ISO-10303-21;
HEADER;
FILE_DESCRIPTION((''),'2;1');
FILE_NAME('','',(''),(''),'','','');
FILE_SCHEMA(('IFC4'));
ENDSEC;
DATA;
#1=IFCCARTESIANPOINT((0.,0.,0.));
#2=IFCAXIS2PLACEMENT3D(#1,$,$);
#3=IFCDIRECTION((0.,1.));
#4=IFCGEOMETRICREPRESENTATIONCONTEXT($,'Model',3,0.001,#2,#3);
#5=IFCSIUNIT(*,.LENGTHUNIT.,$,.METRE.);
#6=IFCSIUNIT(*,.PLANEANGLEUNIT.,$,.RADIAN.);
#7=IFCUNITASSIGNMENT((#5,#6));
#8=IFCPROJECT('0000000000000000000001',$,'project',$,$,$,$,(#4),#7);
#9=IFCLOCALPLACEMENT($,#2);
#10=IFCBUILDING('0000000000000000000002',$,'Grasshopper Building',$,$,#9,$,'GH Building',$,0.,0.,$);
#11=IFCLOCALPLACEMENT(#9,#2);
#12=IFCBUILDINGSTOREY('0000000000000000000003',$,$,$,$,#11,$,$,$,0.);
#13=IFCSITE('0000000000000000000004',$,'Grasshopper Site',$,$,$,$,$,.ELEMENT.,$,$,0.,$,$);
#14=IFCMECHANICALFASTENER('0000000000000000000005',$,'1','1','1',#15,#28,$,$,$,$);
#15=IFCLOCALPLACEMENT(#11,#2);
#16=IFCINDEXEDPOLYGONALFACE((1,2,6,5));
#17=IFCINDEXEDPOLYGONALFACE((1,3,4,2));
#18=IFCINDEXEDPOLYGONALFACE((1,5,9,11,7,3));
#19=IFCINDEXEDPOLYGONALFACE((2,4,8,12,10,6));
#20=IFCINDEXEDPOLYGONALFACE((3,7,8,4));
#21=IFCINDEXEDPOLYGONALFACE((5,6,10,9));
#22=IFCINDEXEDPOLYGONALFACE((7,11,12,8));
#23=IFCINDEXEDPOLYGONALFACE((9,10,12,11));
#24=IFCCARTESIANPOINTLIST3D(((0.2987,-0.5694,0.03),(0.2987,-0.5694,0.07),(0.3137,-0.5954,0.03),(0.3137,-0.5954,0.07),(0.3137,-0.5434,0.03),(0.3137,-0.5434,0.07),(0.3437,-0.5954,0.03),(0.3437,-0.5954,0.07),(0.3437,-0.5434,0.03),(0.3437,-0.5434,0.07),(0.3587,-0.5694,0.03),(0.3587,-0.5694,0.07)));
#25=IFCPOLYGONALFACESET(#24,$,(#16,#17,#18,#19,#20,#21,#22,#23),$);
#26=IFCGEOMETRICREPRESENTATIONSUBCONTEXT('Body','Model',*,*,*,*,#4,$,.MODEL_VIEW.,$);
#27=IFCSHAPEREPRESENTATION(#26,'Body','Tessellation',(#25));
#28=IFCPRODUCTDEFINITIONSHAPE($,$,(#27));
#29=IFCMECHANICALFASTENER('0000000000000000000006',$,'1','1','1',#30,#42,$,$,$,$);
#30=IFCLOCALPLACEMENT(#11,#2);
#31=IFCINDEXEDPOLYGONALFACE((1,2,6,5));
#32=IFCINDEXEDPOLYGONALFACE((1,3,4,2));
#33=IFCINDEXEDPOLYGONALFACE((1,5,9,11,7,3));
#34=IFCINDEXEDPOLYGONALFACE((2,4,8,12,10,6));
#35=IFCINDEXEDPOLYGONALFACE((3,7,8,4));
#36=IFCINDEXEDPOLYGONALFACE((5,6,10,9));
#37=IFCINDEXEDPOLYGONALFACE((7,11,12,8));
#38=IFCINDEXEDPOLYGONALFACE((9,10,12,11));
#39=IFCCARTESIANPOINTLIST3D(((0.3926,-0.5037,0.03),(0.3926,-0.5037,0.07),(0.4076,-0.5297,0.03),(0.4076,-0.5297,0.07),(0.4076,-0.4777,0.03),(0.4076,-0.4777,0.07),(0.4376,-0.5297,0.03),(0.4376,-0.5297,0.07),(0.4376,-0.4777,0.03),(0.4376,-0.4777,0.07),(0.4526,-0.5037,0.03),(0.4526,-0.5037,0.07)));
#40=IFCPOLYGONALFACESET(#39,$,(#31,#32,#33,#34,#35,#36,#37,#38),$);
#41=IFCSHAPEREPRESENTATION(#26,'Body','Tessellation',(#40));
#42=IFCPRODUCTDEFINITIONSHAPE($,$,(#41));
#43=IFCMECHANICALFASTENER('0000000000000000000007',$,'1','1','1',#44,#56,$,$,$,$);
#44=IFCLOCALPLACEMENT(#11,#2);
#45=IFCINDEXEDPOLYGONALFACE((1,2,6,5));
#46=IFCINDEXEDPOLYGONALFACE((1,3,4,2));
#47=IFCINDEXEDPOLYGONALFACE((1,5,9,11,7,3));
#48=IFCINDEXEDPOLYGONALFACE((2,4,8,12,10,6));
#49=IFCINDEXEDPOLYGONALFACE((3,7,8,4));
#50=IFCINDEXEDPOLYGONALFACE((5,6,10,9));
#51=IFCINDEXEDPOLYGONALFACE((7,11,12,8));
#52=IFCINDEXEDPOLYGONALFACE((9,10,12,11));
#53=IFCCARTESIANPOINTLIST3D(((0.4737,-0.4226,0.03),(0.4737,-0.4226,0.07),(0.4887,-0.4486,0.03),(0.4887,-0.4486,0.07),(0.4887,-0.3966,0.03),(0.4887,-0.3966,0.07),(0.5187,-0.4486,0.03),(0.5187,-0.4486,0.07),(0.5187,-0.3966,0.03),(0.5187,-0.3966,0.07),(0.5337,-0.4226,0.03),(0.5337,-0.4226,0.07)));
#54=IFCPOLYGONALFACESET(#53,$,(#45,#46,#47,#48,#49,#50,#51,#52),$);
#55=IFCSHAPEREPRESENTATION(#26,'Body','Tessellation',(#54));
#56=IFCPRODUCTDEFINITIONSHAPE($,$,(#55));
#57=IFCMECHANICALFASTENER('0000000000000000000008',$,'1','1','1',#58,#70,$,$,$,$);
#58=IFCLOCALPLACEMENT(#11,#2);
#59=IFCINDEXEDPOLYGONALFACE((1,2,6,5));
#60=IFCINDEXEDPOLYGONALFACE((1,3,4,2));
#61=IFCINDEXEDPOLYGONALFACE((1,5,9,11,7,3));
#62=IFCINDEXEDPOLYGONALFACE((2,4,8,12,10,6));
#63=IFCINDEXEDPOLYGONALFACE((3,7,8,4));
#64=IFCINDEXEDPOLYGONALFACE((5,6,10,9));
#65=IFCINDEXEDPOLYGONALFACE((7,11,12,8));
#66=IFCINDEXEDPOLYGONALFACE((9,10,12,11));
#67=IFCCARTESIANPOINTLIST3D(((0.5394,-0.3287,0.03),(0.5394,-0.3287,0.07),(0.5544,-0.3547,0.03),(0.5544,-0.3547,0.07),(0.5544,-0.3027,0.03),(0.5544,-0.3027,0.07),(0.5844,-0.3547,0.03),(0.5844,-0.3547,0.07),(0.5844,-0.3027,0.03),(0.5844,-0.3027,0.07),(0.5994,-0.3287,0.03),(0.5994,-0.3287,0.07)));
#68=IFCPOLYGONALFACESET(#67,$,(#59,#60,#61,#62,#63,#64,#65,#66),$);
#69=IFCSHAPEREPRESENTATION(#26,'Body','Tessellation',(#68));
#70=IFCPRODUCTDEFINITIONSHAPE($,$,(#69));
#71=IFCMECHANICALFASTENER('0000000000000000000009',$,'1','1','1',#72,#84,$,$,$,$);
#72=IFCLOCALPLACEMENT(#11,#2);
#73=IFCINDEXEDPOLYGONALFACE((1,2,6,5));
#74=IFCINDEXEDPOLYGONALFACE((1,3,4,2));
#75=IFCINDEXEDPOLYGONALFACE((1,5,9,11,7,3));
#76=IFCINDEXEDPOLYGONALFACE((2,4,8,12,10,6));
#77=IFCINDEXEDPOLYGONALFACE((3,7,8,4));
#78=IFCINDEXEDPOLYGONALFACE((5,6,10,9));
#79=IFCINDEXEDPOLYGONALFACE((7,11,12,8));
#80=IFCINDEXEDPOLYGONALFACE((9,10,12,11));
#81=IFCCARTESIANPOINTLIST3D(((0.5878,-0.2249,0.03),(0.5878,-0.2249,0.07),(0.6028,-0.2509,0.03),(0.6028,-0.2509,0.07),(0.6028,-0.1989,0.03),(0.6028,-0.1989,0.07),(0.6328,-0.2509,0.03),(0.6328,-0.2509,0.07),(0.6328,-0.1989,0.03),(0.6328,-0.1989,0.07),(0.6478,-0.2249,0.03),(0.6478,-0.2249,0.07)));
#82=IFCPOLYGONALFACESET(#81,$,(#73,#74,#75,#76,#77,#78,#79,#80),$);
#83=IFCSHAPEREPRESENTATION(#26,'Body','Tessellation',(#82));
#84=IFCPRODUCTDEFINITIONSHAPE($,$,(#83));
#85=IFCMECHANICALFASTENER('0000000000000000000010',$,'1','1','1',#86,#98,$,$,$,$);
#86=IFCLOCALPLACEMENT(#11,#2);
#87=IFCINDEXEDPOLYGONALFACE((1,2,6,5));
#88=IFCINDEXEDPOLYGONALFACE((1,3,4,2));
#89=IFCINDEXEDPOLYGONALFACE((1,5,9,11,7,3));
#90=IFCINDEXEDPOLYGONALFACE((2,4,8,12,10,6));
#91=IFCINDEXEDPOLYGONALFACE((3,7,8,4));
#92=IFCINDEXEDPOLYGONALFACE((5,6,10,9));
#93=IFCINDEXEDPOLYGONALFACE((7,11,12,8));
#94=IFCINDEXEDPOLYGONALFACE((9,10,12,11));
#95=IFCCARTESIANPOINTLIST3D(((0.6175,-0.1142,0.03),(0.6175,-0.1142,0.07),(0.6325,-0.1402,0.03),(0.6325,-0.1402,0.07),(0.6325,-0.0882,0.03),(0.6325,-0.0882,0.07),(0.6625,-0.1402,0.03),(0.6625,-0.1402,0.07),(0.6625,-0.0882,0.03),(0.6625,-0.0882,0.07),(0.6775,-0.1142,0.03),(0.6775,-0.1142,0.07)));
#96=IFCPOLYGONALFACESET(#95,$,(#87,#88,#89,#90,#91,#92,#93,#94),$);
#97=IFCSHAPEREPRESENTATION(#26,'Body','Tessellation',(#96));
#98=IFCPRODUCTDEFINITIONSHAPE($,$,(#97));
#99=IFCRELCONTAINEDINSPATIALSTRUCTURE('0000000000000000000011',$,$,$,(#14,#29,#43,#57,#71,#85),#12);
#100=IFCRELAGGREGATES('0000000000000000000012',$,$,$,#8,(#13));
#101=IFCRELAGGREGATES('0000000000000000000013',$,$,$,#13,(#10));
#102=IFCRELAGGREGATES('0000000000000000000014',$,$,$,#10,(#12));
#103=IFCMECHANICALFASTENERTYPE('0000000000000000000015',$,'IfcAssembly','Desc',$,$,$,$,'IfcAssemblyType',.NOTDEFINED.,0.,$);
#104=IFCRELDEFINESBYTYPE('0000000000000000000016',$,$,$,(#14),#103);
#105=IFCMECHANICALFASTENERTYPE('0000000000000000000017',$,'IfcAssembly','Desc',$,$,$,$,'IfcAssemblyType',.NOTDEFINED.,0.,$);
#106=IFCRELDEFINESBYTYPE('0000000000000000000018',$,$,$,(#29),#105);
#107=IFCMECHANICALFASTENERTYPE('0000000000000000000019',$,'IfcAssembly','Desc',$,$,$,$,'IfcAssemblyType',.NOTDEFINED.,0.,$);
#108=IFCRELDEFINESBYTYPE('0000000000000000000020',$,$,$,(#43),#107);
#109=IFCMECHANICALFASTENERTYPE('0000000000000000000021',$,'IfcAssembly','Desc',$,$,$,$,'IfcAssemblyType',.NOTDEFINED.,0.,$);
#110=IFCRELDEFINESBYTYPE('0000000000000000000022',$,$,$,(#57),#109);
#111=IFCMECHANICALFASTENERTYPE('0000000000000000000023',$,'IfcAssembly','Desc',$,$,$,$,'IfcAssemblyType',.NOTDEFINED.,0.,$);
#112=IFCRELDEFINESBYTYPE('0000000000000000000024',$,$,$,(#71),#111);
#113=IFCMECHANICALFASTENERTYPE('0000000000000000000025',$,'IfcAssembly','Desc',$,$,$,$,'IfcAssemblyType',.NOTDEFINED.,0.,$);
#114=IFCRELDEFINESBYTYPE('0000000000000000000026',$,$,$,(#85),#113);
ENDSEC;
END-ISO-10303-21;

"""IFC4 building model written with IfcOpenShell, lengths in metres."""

from ifc_helpers import new_model, si_unit, direction, frame, origin, place, context, subcontext, project, spatial, indexed_curve, outline, extrude, source, transform, mapped, type_object, type_shapes, element, save


model = new_model("IFC4")

# Units and contexts
model_context = context("Model", 3, precision=0.001, world=origin(), true_north=direction((0.0, 1.0)))
body_context = subcontext(model_context, "Body", "Model", "MODEL_VIEW")
ifc_project = project(units=[si_unit("LENGTHUNIT", "METRE"), si_unit("PLANEANGLEUNIT", "RADIAN")], contexts=[model_context])

# Site, building, storey
site = spatial("IfcSite", under=ifc_project, Name="Grasshopper Site", CompositionType="ELEMENT", RefElevation=0.0)
building_placement = place(None, origin())
building = spatial("IfcBuilding", under=site, at=building_placement, Name="Grasshopper Building", LongName="GH Building", ElevationOfRefHeight=0.0, ElevationOfTerrain=0.0)
storey_placement = place(building_placement, origin())
storey = spatial("IfcBuildingStorey", under=building, at=storey_placement, Elevation=0.0)

# Mechanical fasteners
mechanical_fastener_type_1 = type_object("IfcMechanicalFastenerType", Name="IfcAssembly", Description="Desc", ElementType="IfcAssemblyType", NominalDiameter=0.0)
shared_shape_1 = source(origin(), body_context, "Body", "SweptSolid", [
    extrude(outline(indexed_curve([(0.03, 0.0), (0.015, 0.026), (-0.015, 0.026), (-0.03, 0.0), (-0.015, -0.026), (0.015, -0.026), (0.03, 0.0)])), frame((0.3287, -0.5694, 0.03)), (0.0, 0.0, 1.0), 0.04),
])
type_shapes(mechanical_fastener_type_1, [shared_shape_1])
mechanical_fastener_1_placement = place(storey_placement, origin())
element("IfcMechanicalFastener", 1, at=mechanical_fastener_1_placement, inside=storey, type_object=mechanical_fastener_type_1, Name="1", Description="1", ObjectType="1", context=body_context, shape_type="MappedRepresentation", body=[
    mapped(shared_shape_1, transform((0.0, 0.0, 0.0), scale=1.0)),
])
mechanical_fastener_type_2 = type_object("IfcMechanicalFastenerType", Name="IfcAssembly", Description="Desc", ElementType="IfcAssemblyType", NominalDiameter=0.0)
shared_shape_2 = source(origin(), body_context, "Body", "SweptSolid", [
    extrude(outline(indexed_curve([(0.03, 0.0), (0.015, 0.026), (-0.015, 0.026), (-0.03, 0.0), (-0.015, -0.026), (0.015, -0.026), (0.03, 0.0)])), frame((0.4226, -0.5037, 0.03)), (0.0, 0.0, 1.0), 0.04),
])
type_shapes(mechanical_fastener_type_2, [shared_shape_2])
mechanical_fastener_2_placement = place(storey_placement, origin())
element("IfcMechanicalFastener", 2, at=mechanical_fastener_2_placement, inside=storey, type_object=mechanical_fastener_type_2, Name="1", Description="1", ObjectType="1", context=body_context, shape_type="MappedRepresentation", body=[
    mapped(shared_shape_2, transform((0.0, 0.0, 0.0), scale=1.0)),
])
mechanical_fastener_type_3 = type_object("IfcMechanicalFastenerType", Name="IfcAssembly", Description="Desc", ElementType="IfcAssemblyType", NominalDiameter=0.0)
shared_shape_3 = source(origin(), body_context, "Body", "SweptSolid", [
    extrude(outline(indexed_curve([(0.03, 0.0), (0.015, 0.026), (-0.015, 0.026), (-0.03, 0.0), (-0.015, -0.026), (0.015, -0.026), (0.03, 0.0)])), frame((0.5037, -0.4226, 0.03)), (0.0, 0.0, 1.0), 0.04),
])
type_shapes(mechanical_fastener_type_3, [shared_shape_3])
mechanical_fastener_3_placement = place(storey_placement, origin())
element("IfcMechanicalFastener", 3, at=mechanical_fastener_3_placement, inside=storey, type_object=mechanical_fastener_type_3, Name="1", Description="1", ObjectType="1", context=body_context, shape_type="MappedRepresentation", body=[
    mapped(shared_shape_3, transform((0.0, 0.0, 0.0), scale=1.0)),
])
mechanical_fastener_type_4 = type_object("IfcMechanicalFastenerType", Name="IfcAssembly", Description="Desc", ElementType="IfcAssemblyType", NominalDiameter=0.0)
shared_shape_4 = source(origin(), body_context, "Body", "SweptSolid", [
    extrude(outline(indexed_curve([(0.03, 0.0), (0.015, 0.026), (-0.015, 0.026), (-0.03, 0.0), (-0.015, -0.026), (0.015, -0.026), (0.03, 0.0)])), frame((0.5694, -0.3287, 0.03)), (0.0, 0.0, 1.0), 0.04),
])
type_shapes(mechanical_fastener_type_4, [shared_shape_4])
mechanical_fastener_4_placement = place(storey_placement, origin())
element("IfcMechanicalFastener", 4, at=mechanical_fastener_4_placement, inside=storey, type_object=mechanical_fastener_type_4, Name="1", Description="1", ObjectType="1", context=body_context, shape_type="MappedRepresentation", body=[
    mapped(shared_shape_4, transform((0.0, 0.0, 0.0), scale=1.0)),
])
mechanical_fastener_type_5 = type_object("IfcMechanicalFastenerType", Name="IfcAssembly", Description="Desc", ElementType="IfcAssemblyType", NominalDiameter=0.0)
shared_shape_5 = source(origin(), body_context, "Body", "SweptSolid", [
    extrude(outline(indexed_curve([(0.03, 0.0), (0.015, 0.026), (-0.015, 0.026), (-0.03, 0.0), (-0.015, -0.026), (0.015, -0.026), (0.03, 0.0)])), frame((0.6178, -0.2249, 0.03)), (0.0, 0.0, 1.0), 0.04),
])
type_shapes(mechanical_fastener_type_5, [shared_shape_5])
mechanical_fastener_5_placement = place(storey_placement, origin())
element("IfcMechanicalFastener", 5, at=mechanical_fastener_5_placement, inside=storey, type_object=mechanical_fastener_type_5, Name="1", Description="1", ObjectType="1", context=body_context, shape_type="MappedRepresentation", body=[
    mapped(shared_shape_5, transform((0.0, 0.0, 0.0), scale=1.0)),
])
mechanical_fastener_type_6 = type_object("IfcMechanicalFastenerType", Name="IfcAssembly", Description="Desc", ElementType="IfcAssemblyType", NominalDiameter=0.0)
shared_shape_6 = source(origin(), body_context, "Body", "SweptSolid", [
    extrude(outline(indexed_curve([(0.03, 0.0), (0.015, 0.026), (-0.015, 0.026), (-0.03, 0.0), (-0.015, -0.026), (0.015, -0.026), (0.03, 0.0)])), frame((0.6475, -0.1142, 0.03)), (0.0, 0.0, 1.0), 0.04),
])
type_shapes(mechanical_fastener_type_6, [shared_shape_6])
mechanical_fastener_6_placement = place(storey_placement, origin())
element("IfcMechanicalFastener", 6, at=mechanical_fastener_6_placement, inside=storey, type_object=mechanical_fastener_type_6, Name="1", Description="1", ObjectType="1", context=body_context, shape_type="MappedRepresentation", body=[
    mapped(shared_shape_6, transform((0.0, 0.0, 0.0), scale=1.0)),
])

save(model, "model.ifc")
